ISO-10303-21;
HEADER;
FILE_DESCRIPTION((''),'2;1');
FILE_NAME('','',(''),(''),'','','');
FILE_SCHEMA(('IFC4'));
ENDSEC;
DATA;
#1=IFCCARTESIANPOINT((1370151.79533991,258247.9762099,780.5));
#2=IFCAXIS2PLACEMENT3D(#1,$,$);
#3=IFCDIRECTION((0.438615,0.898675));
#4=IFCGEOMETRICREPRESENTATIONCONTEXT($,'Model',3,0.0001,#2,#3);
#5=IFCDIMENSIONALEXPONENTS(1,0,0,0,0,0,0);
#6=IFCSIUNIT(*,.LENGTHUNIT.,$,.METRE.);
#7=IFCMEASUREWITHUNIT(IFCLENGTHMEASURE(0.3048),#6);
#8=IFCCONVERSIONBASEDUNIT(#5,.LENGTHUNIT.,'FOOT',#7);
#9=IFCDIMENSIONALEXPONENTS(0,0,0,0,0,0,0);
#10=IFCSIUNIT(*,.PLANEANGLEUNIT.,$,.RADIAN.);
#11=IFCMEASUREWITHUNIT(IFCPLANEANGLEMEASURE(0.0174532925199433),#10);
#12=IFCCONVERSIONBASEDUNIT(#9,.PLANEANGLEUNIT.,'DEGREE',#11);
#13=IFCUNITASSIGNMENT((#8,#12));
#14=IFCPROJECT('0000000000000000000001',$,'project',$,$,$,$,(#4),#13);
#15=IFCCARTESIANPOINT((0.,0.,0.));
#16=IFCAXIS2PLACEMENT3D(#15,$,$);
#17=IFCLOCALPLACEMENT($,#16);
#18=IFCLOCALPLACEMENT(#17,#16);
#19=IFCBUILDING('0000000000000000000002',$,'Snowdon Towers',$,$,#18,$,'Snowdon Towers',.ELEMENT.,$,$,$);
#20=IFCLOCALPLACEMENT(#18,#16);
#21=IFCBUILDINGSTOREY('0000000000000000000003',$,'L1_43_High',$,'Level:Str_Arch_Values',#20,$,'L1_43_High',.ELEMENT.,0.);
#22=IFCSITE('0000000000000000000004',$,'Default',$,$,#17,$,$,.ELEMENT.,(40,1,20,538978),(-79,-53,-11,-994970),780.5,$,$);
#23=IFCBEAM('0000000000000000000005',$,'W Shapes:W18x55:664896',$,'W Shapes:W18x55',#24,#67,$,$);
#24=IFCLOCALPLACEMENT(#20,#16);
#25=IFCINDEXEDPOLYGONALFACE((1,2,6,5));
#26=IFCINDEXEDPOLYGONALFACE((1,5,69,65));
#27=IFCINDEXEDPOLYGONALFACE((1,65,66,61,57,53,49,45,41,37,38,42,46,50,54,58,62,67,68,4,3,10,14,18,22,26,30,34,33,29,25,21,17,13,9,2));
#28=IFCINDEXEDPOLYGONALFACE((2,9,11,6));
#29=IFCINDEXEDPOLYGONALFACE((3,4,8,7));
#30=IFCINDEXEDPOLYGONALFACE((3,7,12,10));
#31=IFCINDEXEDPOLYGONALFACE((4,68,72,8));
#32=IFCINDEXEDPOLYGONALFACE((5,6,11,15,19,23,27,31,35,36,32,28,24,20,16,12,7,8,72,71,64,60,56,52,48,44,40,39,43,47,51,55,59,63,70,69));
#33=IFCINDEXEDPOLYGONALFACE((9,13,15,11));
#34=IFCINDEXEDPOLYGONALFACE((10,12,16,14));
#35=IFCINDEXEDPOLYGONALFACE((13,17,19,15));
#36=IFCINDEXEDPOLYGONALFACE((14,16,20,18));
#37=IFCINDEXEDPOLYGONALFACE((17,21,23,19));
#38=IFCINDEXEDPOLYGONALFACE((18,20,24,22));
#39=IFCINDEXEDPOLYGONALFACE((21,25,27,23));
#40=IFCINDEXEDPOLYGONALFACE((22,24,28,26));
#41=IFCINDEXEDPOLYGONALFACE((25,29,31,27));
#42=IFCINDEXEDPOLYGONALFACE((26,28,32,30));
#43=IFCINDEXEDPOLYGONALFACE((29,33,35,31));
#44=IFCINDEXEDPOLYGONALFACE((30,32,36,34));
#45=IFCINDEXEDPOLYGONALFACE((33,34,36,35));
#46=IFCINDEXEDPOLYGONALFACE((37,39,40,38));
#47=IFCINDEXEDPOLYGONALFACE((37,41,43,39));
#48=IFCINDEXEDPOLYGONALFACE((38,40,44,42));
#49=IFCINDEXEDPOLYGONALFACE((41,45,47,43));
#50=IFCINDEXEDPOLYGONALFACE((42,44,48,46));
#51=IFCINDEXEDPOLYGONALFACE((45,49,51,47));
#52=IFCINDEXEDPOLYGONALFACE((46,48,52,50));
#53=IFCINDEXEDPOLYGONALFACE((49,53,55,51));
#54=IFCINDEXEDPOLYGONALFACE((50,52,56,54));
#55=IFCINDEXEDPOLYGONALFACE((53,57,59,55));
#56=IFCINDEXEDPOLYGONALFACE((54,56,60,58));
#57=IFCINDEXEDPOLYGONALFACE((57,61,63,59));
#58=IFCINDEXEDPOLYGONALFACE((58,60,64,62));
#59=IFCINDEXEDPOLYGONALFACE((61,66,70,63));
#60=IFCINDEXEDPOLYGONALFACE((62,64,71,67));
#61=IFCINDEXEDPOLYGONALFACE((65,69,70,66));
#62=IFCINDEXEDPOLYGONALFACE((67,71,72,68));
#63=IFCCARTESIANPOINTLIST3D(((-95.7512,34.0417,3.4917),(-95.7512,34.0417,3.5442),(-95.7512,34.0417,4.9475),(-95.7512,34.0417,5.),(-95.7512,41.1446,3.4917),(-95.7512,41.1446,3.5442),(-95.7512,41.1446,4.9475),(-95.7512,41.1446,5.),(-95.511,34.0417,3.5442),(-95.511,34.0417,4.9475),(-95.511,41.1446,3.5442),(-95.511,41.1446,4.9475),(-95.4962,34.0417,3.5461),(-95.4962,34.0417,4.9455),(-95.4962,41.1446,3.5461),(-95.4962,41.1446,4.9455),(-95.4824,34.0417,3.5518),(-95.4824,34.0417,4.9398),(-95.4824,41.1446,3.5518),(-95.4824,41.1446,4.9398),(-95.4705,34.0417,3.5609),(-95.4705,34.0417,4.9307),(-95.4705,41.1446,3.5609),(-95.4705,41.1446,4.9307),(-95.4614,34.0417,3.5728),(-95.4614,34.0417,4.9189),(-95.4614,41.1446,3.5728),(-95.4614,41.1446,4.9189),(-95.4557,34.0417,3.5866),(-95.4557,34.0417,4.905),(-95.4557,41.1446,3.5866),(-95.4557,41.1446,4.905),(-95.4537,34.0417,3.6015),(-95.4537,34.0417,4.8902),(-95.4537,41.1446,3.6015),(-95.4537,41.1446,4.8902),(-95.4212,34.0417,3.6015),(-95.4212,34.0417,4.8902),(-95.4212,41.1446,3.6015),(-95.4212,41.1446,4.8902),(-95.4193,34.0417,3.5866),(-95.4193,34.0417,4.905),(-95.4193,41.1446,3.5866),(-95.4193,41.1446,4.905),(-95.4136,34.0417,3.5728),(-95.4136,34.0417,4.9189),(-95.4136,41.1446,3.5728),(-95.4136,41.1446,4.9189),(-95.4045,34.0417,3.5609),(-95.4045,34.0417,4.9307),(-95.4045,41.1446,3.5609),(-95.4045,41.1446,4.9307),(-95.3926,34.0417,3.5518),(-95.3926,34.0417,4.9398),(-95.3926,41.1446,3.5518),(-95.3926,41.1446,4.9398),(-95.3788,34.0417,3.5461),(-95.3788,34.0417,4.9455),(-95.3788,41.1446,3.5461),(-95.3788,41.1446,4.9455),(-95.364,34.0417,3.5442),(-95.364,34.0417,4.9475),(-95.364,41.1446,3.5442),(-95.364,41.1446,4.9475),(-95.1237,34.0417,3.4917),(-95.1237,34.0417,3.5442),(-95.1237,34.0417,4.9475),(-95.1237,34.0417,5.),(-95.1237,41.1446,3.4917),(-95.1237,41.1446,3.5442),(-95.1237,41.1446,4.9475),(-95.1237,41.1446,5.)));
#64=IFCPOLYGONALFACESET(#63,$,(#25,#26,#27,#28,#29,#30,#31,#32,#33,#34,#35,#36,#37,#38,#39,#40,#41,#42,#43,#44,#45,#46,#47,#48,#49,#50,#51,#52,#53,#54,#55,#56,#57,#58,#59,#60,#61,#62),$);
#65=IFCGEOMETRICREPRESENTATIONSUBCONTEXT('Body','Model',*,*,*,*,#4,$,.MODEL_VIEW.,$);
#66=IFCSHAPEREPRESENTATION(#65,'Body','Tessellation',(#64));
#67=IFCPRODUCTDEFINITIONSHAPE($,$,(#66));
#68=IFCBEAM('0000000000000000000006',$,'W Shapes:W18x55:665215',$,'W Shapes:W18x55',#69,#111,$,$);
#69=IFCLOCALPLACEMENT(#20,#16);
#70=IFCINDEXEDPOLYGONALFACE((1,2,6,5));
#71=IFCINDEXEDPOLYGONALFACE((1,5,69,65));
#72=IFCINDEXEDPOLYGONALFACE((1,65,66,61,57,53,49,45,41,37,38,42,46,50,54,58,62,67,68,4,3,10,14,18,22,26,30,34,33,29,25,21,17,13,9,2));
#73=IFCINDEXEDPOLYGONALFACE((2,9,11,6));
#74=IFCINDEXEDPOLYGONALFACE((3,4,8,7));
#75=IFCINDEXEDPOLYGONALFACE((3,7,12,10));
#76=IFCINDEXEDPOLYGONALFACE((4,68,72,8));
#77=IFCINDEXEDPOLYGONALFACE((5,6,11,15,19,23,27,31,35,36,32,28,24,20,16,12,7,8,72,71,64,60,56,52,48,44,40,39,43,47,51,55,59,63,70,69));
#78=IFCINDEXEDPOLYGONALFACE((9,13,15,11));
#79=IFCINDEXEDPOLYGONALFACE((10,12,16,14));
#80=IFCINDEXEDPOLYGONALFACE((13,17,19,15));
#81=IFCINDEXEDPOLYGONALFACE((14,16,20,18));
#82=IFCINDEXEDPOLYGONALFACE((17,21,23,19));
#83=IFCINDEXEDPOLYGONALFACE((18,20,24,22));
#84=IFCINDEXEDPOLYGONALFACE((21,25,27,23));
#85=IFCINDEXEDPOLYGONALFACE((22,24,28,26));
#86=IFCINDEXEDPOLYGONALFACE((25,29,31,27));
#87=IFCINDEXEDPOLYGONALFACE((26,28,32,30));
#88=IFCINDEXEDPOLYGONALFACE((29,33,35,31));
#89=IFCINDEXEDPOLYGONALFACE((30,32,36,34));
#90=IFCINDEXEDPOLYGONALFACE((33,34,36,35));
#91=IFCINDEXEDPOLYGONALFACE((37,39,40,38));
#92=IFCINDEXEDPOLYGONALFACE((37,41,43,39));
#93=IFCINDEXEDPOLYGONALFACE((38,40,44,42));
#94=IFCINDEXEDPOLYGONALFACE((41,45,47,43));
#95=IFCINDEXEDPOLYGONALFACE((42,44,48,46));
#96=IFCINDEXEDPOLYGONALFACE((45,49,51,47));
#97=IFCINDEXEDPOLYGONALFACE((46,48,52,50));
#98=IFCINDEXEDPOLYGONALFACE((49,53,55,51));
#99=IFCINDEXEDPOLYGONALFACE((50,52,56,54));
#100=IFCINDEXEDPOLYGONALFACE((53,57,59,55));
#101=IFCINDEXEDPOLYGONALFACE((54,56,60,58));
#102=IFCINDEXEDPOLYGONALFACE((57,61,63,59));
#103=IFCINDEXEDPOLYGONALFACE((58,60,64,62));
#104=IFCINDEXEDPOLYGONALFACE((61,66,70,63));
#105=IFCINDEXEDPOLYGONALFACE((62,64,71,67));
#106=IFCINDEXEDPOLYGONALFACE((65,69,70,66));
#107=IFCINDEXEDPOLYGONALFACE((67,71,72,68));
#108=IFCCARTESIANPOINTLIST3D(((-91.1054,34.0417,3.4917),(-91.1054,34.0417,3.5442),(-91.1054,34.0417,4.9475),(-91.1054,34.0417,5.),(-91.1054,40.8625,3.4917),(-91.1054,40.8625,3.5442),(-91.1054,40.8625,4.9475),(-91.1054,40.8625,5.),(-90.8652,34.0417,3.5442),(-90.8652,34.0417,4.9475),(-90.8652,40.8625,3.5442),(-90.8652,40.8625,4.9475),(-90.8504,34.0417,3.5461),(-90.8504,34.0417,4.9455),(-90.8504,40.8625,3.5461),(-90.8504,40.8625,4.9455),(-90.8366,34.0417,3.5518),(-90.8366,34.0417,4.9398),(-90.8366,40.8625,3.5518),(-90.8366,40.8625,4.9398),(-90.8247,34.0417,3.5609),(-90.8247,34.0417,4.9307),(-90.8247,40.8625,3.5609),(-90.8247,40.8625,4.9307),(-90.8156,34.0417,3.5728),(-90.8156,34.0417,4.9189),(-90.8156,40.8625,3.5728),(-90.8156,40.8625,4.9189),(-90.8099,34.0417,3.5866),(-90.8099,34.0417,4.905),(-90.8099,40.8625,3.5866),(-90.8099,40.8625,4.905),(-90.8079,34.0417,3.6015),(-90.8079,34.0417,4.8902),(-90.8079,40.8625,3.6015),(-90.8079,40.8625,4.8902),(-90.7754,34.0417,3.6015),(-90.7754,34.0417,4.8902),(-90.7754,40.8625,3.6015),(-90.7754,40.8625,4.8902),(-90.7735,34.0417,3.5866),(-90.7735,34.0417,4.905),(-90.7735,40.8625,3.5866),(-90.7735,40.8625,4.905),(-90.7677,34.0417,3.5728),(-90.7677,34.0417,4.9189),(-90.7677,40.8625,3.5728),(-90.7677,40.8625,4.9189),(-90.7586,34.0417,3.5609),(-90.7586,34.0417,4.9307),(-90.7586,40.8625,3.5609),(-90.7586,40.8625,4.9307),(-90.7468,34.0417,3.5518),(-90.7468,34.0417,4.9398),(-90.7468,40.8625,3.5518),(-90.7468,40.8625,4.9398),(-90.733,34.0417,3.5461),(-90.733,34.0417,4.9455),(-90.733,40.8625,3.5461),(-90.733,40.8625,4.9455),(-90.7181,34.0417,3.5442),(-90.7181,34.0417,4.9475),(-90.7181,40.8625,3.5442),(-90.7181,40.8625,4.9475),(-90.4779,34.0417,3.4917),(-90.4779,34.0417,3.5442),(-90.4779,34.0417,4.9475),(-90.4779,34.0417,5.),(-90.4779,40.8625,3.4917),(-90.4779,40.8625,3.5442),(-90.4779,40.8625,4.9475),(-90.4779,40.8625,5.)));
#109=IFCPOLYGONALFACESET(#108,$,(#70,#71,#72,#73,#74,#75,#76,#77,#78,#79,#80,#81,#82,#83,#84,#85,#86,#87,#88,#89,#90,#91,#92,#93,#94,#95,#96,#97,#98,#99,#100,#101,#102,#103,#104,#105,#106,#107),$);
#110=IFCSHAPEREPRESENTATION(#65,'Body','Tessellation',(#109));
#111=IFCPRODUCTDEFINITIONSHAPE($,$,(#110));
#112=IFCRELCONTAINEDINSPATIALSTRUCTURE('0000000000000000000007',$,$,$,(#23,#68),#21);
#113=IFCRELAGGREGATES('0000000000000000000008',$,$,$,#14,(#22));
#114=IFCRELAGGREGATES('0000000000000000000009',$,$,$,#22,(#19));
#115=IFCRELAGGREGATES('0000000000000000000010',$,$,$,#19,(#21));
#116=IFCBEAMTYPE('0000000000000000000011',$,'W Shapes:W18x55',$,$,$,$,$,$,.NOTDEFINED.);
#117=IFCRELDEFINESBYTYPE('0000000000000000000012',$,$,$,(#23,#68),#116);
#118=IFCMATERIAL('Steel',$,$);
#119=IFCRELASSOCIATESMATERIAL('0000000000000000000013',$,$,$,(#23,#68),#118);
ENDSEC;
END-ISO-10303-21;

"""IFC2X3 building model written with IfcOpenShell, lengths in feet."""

from ifc_helpers import new_model, entity, si_unit, converted_unit, direction, frame, frame_2d, origin, place, context, subcontext, project, spatial, i_section, extrude, material, type_object, element, save


model = new_model("IFC2X3")

# Units and contexts
model_context = context("Model", 3, precision=0.0001, world=frame((1370151.79533991, 258247.9762099, 780.5)), true_north=direction((0.438615, 0.898675)))
body_context = subcontext(model_context, "Body", "Model", "MODEL_VIEW")
ifc_project = project(units=[converted_unit("LENGTHUNIT", "FOOT", entity("IfcLengthMeasure", 0.3048), si_unit("LENGTHUNIT", "METRE"), dimensions=[1, 0, 0, 0, 0, 0, 0]), converted_unit("PLANEANGLEUNIT", "DEGREE", entity("IfcPlaneAngleMeasure", 0.0174532925199433), si_unit("PLANEANGLEUNIT", "RADIAN"), dimensions=[0, 0, 0, 0, 0, 0, 0])], contexts=[model_context])

# Site, building, storey
site_placement = place(None, origin())
site = spatial("IfcSite", under=ifc_project, at=site_placement, Name="Default", CompositionType="ELEMENT", RefLatitude=(40, 1, 20, 538978), RefLongitude=(-79, -53, -11, -994970), RefElevation=780.5)
building_placement = place(site_placement, origin())
building = spatial("IfcBuilding", under=site, at=building_placement, Name="Snowdon Towers", LongName="Snowdon Towers", CompositionType="ELEMENT")
storey_placement = place(building_placement, origin())
storey = spatial("IfcBuildingStorey", under=building, at=storey_placement, Name="L1_43_High", ObjectType="Level:Str_Arch_Values", LongName="L1_43_High", CompositionType="ELEMENT", Elevation=0.0)

# Beams
ifc_material_1 = material(Name="Steel")
beam_type = type_object("IfcBeamType", Name="W Shapes:W18x55", PredefinedType="NOTDEFINED")
beam_1_placement = place(storey_placement, frame((-95.4375, 41.4583, 5.0), z_axis=(0.0, 0.0, 1.0), x_axis=(0.0, -1.0, 0.0)))
element("IfcBeam", 1, at=beam_1_placement, inside=storey, type_object=beam_type, material=ifc_material_1, Name="W Shapes:W18x55:664896", ObjectType="W Shapes:W18x55", context=body_context, shape_type="SweptSolid", body=[
    extrude(i_section(OverallWidth=0.6275, OverallDepth=1.5083, WebThickness=0.0325, FlangeThickness=0.0525, FilletRadius=0.0573, at=frame_2d((0.0, 0.0), x_axis=(0.0, 1.0))), frame((0.3138, 0.0, -0.7542), z_axis=(1.0, 0.0, 0.0), x_axis=(0.0, 0.0, -1.0)), (0.0, 0.0, 1.0), 7.1029),
])
beam_2_placement = place(storey_placement, frame((-90.7917, 41.4583, 5.0), z_axis=(0.0, 0.0, 1.0), x_axis=(0.0, -1.0, 0.0)))
element("IfcBeam", 2, at=beam_2_placement, inside=storey, type_object=beam_type, material=ifc_material_1, Name="W Shapes:W18x55:665215", ObjectType="W Shapes:W18x55", context=body_context, shape_type="SweptSolid", body=[
    extrude(i_section(OverallWidth=0.6275, OverallDepth=1.5083, WebThickness=0.0325, FlangeThickness=0.0525, FilletRadius=0.0573, at=frame_2d((0.0, 0.0), x_axis=(0.0, 1.0))), frame((0.5958, 0.0, -0.7542), z_axis=(1.0, 0.0, 0.0), x_axis=(0.0, 0.0, -1.0)), (0.0, 0.0, 1.0), 6.8208),
])

save(model, "model.ifc")
